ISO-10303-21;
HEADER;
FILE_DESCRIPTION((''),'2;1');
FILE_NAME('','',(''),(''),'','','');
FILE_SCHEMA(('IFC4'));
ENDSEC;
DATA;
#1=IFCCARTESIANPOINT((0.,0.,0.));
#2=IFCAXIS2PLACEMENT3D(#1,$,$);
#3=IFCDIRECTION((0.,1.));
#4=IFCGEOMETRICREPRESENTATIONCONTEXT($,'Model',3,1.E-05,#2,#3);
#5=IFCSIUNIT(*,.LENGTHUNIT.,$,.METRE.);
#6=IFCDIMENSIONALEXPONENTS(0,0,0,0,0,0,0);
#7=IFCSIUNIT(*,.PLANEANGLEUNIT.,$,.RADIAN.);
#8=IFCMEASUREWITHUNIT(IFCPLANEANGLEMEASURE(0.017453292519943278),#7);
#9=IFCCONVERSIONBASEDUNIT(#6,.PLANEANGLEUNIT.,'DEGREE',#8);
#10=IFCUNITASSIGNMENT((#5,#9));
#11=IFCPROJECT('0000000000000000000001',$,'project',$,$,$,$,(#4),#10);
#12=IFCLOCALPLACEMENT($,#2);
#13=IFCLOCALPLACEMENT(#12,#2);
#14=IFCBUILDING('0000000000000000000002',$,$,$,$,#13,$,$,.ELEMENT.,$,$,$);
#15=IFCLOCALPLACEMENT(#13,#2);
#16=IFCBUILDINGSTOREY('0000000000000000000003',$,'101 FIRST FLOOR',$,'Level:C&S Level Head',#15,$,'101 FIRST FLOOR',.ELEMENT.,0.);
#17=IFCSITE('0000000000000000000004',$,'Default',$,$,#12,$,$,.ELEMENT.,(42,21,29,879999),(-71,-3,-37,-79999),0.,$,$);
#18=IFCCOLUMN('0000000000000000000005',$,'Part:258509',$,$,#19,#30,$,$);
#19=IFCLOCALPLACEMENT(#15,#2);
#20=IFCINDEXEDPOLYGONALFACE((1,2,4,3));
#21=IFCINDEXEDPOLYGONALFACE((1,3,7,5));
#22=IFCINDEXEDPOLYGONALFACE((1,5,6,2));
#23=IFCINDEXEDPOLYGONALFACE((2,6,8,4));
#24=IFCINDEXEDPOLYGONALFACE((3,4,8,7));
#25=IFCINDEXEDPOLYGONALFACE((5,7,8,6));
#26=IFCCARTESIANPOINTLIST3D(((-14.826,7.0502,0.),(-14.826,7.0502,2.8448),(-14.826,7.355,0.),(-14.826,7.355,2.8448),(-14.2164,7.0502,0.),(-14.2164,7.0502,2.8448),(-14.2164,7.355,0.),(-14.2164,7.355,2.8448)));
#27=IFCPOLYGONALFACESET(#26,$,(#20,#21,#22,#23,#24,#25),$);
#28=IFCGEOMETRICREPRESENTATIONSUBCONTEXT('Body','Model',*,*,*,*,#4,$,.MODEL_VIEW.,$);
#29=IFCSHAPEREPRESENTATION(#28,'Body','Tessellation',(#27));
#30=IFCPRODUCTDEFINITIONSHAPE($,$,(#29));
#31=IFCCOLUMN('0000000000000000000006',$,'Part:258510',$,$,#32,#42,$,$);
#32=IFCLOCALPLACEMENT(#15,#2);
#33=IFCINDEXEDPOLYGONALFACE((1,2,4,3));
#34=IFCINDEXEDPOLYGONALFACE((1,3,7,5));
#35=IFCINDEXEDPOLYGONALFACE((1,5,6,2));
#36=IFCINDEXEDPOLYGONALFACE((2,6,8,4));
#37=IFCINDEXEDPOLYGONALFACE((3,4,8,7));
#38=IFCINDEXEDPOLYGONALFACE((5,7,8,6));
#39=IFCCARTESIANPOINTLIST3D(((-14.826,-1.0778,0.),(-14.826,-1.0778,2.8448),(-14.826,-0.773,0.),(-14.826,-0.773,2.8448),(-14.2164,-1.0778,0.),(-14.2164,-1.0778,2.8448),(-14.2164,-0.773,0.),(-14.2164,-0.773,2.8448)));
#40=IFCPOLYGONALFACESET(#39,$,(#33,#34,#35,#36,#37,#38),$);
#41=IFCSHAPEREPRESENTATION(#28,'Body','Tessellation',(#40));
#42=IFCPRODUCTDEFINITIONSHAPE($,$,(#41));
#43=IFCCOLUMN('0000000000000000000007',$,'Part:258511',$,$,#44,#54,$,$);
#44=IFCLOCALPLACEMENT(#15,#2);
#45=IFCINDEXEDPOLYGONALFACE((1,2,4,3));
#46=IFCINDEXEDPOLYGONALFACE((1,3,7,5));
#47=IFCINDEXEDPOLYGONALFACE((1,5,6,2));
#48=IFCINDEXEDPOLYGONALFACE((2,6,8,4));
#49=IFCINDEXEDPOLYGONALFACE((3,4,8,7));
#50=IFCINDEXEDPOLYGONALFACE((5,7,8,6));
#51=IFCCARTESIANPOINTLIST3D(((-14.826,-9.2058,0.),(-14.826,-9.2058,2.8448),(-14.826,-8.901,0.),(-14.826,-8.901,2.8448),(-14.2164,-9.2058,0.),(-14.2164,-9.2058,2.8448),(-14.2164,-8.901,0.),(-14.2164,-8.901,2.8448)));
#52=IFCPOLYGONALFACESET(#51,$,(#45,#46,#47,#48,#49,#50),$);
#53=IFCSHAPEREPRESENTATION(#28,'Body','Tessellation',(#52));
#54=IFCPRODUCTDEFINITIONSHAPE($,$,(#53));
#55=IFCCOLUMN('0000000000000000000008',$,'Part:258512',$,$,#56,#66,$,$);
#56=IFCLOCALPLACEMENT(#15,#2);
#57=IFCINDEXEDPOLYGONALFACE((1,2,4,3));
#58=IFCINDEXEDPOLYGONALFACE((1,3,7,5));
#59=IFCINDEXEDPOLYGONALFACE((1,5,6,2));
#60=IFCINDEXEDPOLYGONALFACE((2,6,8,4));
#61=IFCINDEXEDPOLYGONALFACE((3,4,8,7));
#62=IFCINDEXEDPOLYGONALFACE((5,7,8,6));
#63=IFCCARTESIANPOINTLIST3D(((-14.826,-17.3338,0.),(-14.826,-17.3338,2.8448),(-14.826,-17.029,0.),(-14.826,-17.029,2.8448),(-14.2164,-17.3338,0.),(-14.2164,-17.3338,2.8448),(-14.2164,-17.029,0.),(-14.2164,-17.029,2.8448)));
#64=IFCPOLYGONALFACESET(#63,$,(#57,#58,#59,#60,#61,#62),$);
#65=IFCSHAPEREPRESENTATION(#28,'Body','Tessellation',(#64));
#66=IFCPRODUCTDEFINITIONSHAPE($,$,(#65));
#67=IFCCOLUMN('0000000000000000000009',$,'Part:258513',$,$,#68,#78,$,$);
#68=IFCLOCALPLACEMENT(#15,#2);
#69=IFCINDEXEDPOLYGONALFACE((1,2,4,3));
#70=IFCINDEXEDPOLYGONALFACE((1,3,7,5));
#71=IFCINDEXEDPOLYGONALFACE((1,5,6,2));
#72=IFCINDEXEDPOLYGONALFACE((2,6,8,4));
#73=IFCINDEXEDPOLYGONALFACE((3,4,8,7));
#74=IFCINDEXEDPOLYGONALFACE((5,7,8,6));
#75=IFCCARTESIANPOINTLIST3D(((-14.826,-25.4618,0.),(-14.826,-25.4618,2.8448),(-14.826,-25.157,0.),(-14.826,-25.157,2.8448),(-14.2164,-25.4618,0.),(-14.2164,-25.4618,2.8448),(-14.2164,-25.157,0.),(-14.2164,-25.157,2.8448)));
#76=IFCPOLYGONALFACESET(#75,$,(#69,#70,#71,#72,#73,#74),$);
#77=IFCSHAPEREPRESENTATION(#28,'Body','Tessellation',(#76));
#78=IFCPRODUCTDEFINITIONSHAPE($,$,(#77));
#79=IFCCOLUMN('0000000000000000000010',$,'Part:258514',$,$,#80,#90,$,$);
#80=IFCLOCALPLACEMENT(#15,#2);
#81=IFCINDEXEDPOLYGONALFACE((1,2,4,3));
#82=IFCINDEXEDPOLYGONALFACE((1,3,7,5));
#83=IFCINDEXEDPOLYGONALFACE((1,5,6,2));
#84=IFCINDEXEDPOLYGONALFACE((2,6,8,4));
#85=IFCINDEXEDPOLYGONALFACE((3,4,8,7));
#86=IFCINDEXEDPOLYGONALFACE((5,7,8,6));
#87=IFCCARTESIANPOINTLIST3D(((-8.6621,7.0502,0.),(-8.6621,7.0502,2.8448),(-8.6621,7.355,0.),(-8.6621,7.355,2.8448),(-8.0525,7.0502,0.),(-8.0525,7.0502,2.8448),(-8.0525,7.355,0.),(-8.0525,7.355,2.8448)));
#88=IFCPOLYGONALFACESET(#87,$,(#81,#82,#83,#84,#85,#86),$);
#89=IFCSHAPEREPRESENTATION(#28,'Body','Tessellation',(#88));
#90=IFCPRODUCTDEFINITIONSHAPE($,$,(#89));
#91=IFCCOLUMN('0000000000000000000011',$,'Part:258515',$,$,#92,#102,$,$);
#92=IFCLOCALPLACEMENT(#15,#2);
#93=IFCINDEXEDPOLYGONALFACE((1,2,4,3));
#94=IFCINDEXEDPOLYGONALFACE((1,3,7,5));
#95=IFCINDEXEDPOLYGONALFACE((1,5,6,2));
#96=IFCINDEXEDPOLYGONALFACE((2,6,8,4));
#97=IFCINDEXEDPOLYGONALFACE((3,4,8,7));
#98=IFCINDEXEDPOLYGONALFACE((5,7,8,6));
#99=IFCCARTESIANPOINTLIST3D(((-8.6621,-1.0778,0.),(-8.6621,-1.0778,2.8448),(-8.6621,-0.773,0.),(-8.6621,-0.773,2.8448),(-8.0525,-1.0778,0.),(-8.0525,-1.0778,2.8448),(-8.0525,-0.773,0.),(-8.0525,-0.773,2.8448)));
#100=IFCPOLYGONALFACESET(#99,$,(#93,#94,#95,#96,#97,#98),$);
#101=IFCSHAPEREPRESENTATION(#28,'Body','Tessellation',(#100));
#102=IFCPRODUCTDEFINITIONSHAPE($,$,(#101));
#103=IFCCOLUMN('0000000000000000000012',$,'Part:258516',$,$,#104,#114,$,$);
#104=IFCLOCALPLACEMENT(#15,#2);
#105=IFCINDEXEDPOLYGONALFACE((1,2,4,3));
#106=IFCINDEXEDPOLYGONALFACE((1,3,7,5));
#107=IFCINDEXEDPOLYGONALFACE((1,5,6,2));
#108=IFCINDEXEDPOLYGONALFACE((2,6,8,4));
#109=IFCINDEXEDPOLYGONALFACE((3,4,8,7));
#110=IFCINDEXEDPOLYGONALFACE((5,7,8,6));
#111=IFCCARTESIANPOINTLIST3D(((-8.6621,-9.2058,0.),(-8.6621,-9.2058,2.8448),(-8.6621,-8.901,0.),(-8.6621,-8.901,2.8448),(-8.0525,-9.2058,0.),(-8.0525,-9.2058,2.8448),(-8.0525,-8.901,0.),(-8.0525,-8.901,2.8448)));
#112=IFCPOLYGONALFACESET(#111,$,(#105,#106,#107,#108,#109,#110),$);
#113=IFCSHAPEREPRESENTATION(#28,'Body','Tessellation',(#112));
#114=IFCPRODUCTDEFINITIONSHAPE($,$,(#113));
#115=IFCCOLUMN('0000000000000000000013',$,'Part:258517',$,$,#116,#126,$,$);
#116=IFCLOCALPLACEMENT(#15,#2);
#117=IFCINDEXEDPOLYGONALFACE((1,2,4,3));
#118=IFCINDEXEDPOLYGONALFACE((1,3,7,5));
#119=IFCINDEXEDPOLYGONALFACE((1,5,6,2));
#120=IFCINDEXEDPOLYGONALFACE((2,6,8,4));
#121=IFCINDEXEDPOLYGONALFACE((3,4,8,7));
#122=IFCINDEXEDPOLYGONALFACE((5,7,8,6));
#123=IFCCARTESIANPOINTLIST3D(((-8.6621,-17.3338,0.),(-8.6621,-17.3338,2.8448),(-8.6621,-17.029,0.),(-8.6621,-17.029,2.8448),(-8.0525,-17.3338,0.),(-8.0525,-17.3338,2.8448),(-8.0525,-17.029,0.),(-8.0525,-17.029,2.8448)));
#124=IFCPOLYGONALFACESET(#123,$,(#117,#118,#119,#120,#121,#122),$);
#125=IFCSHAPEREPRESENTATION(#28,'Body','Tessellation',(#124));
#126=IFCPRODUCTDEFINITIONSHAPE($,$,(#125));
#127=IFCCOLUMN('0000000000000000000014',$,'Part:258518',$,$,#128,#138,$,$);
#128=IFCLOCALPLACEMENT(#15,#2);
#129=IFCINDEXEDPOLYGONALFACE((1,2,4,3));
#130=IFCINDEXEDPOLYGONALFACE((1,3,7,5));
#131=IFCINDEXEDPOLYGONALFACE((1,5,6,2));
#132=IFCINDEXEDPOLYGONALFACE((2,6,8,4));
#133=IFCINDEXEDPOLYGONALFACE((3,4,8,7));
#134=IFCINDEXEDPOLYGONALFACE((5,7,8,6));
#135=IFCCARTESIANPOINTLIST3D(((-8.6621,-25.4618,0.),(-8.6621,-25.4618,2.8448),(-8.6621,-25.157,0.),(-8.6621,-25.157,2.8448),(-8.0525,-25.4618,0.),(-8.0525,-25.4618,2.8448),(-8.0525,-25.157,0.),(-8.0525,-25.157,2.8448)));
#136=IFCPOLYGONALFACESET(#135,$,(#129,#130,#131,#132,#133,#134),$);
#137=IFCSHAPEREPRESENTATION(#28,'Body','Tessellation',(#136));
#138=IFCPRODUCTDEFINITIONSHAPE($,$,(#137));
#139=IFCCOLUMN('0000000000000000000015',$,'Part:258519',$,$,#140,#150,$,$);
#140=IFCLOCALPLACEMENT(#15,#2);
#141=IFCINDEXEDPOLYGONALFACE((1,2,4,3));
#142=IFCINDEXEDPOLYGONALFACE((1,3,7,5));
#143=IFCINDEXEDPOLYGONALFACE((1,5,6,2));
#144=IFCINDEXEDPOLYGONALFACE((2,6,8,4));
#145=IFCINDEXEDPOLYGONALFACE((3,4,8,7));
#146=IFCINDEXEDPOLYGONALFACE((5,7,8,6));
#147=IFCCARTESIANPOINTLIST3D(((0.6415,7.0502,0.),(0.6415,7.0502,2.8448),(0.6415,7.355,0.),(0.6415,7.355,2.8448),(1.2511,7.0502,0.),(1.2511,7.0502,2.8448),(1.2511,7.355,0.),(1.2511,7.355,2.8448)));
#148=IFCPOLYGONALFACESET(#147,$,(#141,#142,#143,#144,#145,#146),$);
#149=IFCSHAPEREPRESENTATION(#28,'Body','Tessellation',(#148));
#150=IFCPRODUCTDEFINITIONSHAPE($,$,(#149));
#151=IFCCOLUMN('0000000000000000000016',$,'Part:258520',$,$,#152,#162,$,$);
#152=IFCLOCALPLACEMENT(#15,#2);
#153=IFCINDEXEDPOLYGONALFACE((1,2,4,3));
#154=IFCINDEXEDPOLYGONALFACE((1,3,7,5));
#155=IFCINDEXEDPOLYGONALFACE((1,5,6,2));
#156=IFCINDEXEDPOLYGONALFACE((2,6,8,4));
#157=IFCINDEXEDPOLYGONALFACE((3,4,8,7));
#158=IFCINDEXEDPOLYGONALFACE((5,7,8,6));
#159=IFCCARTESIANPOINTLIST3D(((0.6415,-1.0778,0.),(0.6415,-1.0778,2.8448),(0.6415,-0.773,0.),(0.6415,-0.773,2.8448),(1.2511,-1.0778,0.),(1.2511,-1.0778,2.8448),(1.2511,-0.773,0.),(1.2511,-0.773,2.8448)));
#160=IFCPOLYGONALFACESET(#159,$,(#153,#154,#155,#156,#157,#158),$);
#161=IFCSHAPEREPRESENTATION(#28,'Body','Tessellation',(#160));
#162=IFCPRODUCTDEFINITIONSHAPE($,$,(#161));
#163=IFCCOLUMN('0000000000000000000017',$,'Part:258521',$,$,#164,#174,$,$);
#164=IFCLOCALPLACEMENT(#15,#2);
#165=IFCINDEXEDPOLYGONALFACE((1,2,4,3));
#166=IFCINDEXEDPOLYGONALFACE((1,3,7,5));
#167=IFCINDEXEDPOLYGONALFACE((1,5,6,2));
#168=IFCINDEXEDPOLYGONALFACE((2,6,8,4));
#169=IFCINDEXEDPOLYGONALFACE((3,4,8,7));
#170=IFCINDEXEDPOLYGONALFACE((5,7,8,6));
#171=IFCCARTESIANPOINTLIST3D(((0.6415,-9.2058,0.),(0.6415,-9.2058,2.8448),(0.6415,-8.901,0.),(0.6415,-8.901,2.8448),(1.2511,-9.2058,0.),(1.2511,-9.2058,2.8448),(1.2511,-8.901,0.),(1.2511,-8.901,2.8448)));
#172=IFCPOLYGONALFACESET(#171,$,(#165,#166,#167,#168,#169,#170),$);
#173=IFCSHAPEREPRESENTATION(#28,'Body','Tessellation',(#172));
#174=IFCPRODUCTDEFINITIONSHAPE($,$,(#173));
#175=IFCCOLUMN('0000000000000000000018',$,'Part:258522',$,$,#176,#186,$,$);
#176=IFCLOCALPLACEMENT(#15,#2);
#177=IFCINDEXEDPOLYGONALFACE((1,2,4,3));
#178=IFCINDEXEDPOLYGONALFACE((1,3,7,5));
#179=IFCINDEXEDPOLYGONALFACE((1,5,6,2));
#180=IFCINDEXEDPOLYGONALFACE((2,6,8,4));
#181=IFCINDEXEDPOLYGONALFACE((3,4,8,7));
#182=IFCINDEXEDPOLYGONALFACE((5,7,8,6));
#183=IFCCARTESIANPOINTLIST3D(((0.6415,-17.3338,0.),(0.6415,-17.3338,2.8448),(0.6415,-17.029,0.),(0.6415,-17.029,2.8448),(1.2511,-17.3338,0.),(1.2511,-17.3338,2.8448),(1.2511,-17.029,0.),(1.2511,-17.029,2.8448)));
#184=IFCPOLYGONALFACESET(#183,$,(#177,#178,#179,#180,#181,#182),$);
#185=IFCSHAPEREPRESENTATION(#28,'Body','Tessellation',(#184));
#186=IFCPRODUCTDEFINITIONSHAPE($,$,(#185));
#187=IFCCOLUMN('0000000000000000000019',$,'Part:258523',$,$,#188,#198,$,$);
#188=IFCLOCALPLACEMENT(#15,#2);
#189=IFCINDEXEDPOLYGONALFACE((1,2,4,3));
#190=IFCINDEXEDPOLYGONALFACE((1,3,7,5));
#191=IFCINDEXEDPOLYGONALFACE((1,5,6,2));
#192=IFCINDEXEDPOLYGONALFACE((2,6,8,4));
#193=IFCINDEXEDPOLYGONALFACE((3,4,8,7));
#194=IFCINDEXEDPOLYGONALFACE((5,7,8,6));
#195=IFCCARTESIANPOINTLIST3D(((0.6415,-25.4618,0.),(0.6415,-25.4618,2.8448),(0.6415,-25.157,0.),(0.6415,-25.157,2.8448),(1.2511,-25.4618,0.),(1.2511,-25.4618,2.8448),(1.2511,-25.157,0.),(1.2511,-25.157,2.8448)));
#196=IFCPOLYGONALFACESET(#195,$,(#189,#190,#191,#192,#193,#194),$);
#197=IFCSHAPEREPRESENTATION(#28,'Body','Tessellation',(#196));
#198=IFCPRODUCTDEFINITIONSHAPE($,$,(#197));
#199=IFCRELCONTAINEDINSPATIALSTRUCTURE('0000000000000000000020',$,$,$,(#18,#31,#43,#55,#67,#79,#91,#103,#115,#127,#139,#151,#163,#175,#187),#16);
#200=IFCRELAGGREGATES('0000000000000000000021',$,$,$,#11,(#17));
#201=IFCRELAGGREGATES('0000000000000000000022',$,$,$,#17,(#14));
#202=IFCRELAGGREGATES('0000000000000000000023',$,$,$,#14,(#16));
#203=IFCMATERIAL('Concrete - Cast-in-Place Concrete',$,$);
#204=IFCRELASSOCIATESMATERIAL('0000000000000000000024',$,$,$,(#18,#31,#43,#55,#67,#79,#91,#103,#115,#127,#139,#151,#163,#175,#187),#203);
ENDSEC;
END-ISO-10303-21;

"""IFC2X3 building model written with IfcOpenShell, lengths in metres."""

from ifc_helpers import new_model, entity, si_unit, converted_unit, direction, frame, origin, origin_2d_with_axis, place, context, subcontext, project, spatial, rectangle, extrude, material, element, save


model = new_model("IFC2X3")

# Units and contexts
model_context = context("Model", 3, precision=1e-05, world=origin(), true_north=direction((0.0, 1.0)))
body_context = subcontext(model_context, "Body", "Model", "MODEL_VIEW")
ifc_project = project(units=[si_unit("LENGTHUNIT", "METRE"), converted_unit("PLANEANGLEUNIT", "DEGREE", entity("IfcPlaneAngleMeasure", 0.017453292519943278), si_unit("PLANEANGLEUNIT", "RADIAN"), dimensions=[0, 0, 0, 0, 0, 0, 0])], contexts=[model_context])

# Site, building, storey
site_placement = place(None, origin())
site = spatial("IfcSite", under=ifc_project, at=site_placement, Name="Default", CompositionType="ELEMENT", RefLatitude=(42, 21, 29, 879999), RefLongitude=(-71, -3, -37, -79999), RefElevation=0.0)
building_placement = place(site_placement, origin())
building = spatial("IfcBuilding", under=site, at=building_placement, CompositionType="ELEMENT")
storey_placement = place(building_placement, origin())
storey = spatial("IfcBuildingStorey", under=building, at=storey_placement, Name="101 FIRST FLOOR", ObjectType="Level:C&S Level Head", LongName="101 FIRST FLOOR", CompositionType="ELEMENT", Elevation=0.0)

# Columns
ifc_material = material(Name="Concrete - Cast-in-Place Concrete")
column_1_placement = place(storey_placement, origin())
element("IfcColumn", 1, at=column_1_placement, inside=storey, material=ifc_material, Name="Part:258509", context=body_context, shape_type="SweptSolid", body=[
    extrude(rectangle(XDim=2.8448, YDim=0.3048, at=origin_2d_with_axis()), frame((-14.826, 7.2026, 1.4224), z_axis=(1.0, 0.0, 0.0), x_axis=(0.0, 0.0, -1.0)), (0.0, 0.0, 1.0), 0.6096),
])
column_2_placement = place(storey_placement, origin())
element("IfcColumn", 2, at=column_2_placement, inside=storey, material=ifc_material, Name="Part:258510", context=body_context, shape_type="SweptSolid", body=[
    extrude(rectangle(XDim=2.8448, YDim=0.3048, at=origin_2d_with_axis()), frame((-14.826, -0.9254, 1.4224), z_axis=(1.0, 0.0, 0.0), x_axis=(0.0, 0.0, -1.0)), (0.0, 0.0, 1.0), 0.6096),
])
column_3_placement = place(storey_placement, origin())
element("IfcColumn", 3, at=column_3_placement, inside=storey, material=ifc_material, Name="Part:258511", context=body_context, shape_type="SweptSolid", body=[
    extrude(rectangle(XDim=2.8448, YDim=0.3048, at=origin_2d_with_axis()), frame((-14.826, -9.0534, 1.4224), z_axis=(1.0, 0.0, 0.0), x_axis=(0.0, 0.0, -1.0)), (0.0, 0.0, 1.0), 0.6096),
])
column_4_placement = place(storey_placement, origin())
element("IfcColumn", 4, at=column_4_placement, inside=storey, material=ifc_material, Name="Part:258512", context=body_context, shape_type="SweptSolid", body=[
    extrude(rectangle(XDim=2.8448, YDim=0.3048, at=origin_2d_with_axis()), frame((-14.826, -17.1814, 1.4224), z_axis=(1.0, 0.0, 0.0), x_axis=(0.0, 0.0, -1.0)), (0.0, 0.0, 1.0), 0.6096),
])
column_5_placement = place(storey_placement, origin())
element("IfcColumn", 5, at=column_5_placement, inside=storey, material=ifc_material, Name="Part:258513", context=body_context, shape_type="SweptSolid", body=[
    extrude(rectangle(XDim=2.8448, YDim=0.3048, at=origin_2d_with_axis()), frame((-14.826, -25.3094, 1.4224), z_axis=(1.0, 0.0, 0.0), x_axis=(0.0, 0.0, -1.0)), (0.0, 0.0, 1.0), 0.6096),
])
column_6_placement = place(storey_placement, origin())
element("IfcColumn", 6, at=column_6_placement, inside=storey, material=ifc_material, Name="Part:258514", context=body_context, shape_type="SweptSolid", body=[
    extrude(rectangle(XDim=2.8448, YDim=0.3048, at=origin_2d_with_axis()), frame((-8.6621, 7.2026, 1.4224), z_axis=(1.0, 0.0, 0.0), x_axis=(0.0, 0.0, -1.0)), (0.0, 0.0, 1.0), 0.6096),
])
column_7_placement = place(storey_placement, origin())
element("IfcColumn", 7, at=column_7_placement, inside=storey, material=ifc_material, Name="Part:258515", context=body_context, shape_type="SweptSolid", body=[
    extrude(rectangle(XDim=2.8448, YDim=0.3048, at=origin_2d_with_axis()), frame((-8.6621, -0.9254, 1.4224), z_axis=(1.0, 0.0, 0.0), x_axis=(0.0, 0.0, -1.0)), (0.0, 0.0, 1.0), 0.6096),
])
column_8_placement = place(storey_placement, origin())
element("IfcColumn", 8, at=column_8_placement, inside=storey, material=ifc_material, Name="Part:258516", context=body_context, shape_type="SweptSolid", body=[
    extrude(rectangle(XDim=2.8448, YDim=0.3048, at=origin_2d_with_axis()), frame((-8.6621, -9.0534, 1.4224), z_axis=(1.0, 0.0, 0.0), x_axis=(0.0, 0.0, -1.0)), (0.0, 0.0, 1.0), 0.6096),
])
column_9_placement = place(storey_placement, origin())
element("IfcColumn", 9, at=column_9_placement, inside=storey, material=ifc_material, Name="Part:258517", context=body_context, shape_type="SweptSolid", body=[
    extrude(rectangle(XDim=2.8448, YDim=0.3048, at=origin_2d_with_axis()), frame((-8.6621, -17.1814, 1.4224), z_axis=(1.0, 0.0, 0.0), x_axis=(0.0, 0.0, -1.0)), (0.0, 0.0, 1.0), 0.6096),
])
column_10_placement = place(storey_placement, origin())
element("IfcColumn", 10, at=column_10_placement, inside=storey, material=ifc_material, Name="Part:258518", context=body_context, shape_type="SweptSolid", body=[
    extrude(rectangle(XDim=2.8448, YDim=0.3048, at=origin_2d_with_axis()), frame((-8.6621, -25.3094, 1.4224), z_axis=(1.0, 0.0, 0.0), x_axis=(0.0, 0.0, -1.0)), (0.0, 0.0, 1.0), 0.6096),
])
column_11_placement = place(storey_placement, origin())
element("IfcColumn", 11, at=column_11_placement, inside=storey, material=ifc_material, Name="Part:258519", context=body_context, shape_type="SweptSolid", body=[
    extrude(rectangle(XDim=2.8448, YDim=0.3048, at=origin_2d_with_axis()), frame((0.6415, 7.2026, 1.4224), z_axis=(1.0, 0.0, 0.0), x_axis=(0.0, 0.0, -1.0)), (0.0, 0.0, 1.0), 0.6096),
])
column_12_placement = place(storey_placement, origin())
element("IfcColumn", 12, at=column_12_placement, inside=storey, material=ifc_material, Name="Part:258520", context=body_context, shape_type="SweptSolid", body=[
    extrude(rectangle(XDim=2.8448, YDim=0.3048, at=origin_2d_with_axis()), frame((0.6415, -0.9254, 1.4224), z_axis=(1.0, 0.0, 0.0), x_axis=(0.0, 0.0, -1.0)), (0.0, 0.0, 1.0), 0.6096),
])
column_13_placement = place(storey_placement, origin())
element("IfcColumn", 13, at=column_13_placement, inside=storey, material=ifc_material, Name="Part:258521", context=body_context, shape_type="SweptSolid", body=[
    extrude(rectangle(XDim=2.8448, YDim=0.3048, at=origin_2d_with_axis()), frame((0.6415, -9.0534, 1.4224), z_axis=(1.0, 0.0, 0.0), x_axis=(0.0, 0.0, -1.0)), (0.0, 0.0, 1.0), 0.6096),
])
column_14_placement = place(storey_placement, origin())
element("IfcColumn", 14, at=column_14_placement, inside=storey, material=ifc_material, Name="Part:258522", context=body_context, shape_type="SweptSolid", body=[
    extrude(rectangle(XDim=2.8448, YDim=0.3048, at=origin_2d_with_axis()), frame((0.6415, -17.1814, 1.4224), z_axis=(1.0, 0.0, 0.0), x_axis=(0.0, 0.0, -1.0)), (0.0, 0.0, 1.0), 0.6096),
])
column_15_placement = place(storey_placement, origin())
element("IfcColumn", 15, at=column_15_placement, inside=storey, material=ifc_material, Name="Part:258523", context=body_context, shape_type="SweptSolid", body=[
    extrude(rectangle(XDim=2.8448, YDim=0.3048, at=origin_2d_with_axis()), frame((0.6415, -25.3094, 1.4224), z_axis=(1.0, 0.0, 0.0), x_axis=(0.0, 0.0, -1.0)), (0.0, 0.0, 1.0), 0.6096),
])

save(model, "model.ifc")
